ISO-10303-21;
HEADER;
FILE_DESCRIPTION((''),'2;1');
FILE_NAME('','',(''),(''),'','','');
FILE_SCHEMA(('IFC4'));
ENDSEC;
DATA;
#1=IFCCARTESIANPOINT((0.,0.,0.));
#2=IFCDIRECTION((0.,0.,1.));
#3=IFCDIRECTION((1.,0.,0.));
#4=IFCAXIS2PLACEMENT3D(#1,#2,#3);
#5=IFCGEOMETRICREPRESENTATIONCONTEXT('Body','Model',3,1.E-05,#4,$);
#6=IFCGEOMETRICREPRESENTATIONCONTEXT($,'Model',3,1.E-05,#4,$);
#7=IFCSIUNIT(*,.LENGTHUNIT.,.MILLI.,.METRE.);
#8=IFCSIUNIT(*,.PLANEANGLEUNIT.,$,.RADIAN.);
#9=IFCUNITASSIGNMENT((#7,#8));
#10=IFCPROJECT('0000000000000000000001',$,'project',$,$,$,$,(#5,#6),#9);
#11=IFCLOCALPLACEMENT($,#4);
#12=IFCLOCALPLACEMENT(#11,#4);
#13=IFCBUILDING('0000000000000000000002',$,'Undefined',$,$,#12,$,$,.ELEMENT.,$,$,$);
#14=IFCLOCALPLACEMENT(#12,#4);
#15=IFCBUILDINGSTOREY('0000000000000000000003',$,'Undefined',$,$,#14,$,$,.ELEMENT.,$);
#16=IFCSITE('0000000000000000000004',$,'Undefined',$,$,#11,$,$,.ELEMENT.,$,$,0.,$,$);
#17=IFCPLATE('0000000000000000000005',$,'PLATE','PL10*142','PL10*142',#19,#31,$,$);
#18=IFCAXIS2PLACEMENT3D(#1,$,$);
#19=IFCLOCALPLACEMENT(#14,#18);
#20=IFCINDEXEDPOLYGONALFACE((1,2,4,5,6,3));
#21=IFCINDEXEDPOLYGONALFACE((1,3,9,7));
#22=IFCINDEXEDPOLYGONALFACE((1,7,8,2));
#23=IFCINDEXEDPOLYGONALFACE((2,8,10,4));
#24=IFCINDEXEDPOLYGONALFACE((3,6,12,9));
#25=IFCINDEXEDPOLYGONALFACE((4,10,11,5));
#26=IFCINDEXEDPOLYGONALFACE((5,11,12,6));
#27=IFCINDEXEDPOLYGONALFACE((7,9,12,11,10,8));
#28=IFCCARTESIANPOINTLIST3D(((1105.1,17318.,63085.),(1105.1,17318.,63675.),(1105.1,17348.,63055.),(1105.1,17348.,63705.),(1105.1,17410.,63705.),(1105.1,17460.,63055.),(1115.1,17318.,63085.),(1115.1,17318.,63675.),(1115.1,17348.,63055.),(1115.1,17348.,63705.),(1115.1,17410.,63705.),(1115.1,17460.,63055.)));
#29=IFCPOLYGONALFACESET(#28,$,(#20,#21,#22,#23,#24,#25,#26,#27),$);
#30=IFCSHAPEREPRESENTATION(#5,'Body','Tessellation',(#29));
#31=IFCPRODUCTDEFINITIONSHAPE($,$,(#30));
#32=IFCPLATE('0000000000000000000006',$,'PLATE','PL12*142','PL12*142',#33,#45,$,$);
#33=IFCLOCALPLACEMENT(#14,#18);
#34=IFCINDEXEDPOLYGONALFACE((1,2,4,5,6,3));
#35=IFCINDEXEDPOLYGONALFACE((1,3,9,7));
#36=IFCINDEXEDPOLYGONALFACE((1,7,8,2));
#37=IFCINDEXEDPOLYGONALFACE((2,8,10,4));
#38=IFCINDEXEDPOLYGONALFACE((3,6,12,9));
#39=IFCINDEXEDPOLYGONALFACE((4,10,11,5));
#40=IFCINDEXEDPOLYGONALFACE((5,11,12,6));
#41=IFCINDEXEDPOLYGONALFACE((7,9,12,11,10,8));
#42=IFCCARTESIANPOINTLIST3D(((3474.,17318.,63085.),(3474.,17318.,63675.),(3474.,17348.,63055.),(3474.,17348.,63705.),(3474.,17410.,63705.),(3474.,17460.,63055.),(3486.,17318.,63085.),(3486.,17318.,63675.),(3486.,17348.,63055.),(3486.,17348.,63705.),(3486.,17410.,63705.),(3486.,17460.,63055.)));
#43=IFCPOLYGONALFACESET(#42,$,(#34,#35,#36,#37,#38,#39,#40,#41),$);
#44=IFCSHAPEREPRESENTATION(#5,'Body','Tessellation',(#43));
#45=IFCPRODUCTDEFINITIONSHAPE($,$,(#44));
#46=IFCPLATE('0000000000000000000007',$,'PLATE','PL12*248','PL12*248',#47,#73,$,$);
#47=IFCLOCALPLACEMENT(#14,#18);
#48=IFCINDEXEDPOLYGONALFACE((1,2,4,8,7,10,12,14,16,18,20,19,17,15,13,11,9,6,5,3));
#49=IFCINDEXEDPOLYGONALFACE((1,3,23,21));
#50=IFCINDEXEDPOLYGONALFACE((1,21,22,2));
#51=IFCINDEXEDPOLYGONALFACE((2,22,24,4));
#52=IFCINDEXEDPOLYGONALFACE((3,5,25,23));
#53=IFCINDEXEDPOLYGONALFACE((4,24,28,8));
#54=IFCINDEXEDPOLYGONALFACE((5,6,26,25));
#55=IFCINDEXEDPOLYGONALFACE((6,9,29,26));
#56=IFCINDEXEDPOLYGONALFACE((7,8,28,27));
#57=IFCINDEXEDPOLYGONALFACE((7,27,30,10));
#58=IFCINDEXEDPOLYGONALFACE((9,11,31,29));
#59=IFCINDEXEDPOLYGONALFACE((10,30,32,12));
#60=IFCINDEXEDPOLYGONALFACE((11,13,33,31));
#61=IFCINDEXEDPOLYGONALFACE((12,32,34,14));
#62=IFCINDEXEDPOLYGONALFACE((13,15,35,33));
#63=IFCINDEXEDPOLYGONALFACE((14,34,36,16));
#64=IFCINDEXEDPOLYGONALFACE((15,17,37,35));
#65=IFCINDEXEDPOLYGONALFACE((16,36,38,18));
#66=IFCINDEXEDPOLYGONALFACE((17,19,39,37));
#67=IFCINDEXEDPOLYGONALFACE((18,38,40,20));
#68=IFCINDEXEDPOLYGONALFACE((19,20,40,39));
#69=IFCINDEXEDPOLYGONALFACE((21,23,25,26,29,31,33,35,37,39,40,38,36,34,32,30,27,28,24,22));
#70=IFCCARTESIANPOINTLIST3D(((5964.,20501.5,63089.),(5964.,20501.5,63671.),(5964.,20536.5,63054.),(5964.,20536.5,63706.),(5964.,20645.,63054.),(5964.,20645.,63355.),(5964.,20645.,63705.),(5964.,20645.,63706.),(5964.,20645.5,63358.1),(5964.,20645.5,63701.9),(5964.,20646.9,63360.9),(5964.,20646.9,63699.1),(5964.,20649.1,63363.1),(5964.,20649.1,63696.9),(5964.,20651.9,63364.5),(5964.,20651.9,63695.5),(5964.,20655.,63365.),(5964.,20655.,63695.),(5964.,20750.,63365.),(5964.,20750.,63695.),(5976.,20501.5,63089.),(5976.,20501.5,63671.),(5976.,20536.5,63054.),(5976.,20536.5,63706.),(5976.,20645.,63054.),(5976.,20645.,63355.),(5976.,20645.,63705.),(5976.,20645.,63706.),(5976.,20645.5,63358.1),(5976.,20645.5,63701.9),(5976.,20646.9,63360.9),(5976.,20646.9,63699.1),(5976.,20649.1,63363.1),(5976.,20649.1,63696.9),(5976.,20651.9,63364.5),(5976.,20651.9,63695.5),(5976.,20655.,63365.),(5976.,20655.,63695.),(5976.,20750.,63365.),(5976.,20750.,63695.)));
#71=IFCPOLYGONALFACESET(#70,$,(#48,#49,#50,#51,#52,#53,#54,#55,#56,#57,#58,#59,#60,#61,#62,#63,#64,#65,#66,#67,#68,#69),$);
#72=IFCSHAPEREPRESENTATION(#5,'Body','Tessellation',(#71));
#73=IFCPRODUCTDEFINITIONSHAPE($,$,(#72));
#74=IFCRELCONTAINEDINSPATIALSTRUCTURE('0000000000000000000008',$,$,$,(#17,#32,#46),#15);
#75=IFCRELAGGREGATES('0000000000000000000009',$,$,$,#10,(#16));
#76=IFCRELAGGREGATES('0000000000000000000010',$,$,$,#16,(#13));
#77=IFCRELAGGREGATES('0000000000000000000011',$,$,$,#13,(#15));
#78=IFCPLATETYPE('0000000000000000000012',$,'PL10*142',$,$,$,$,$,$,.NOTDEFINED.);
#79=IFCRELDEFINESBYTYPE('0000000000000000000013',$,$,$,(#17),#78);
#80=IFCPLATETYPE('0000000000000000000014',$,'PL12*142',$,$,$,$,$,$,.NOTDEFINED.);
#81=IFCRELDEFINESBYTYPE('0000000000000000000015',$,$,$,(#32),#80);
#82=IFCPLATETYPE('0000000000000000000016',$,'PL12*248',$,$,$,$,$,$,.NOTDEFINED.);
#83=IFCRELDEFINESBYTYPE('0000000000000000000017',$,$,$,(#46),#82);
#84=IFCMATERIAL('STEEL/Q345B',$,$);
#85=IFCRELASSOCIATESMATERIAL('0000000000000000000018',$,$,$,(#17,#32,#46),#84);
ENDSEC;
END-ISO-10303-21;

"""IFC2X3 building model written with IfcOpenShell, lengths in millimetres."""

from ifc_helpers import new_model, si_unit, frame, origin_with_axes, place, context, project, spatial, polyline, outline, extrude, material, type_object, element, save


model = new_model("IFC2X3")

# Units and contexts
model_context_1 = context("Model", 3, precision=1e-05, world=origin_with_axes(), identifier="Body")
model_context_2 = context("Model", 3, precision=1e-05, world=origin_with_axes())
ifc_project = project(units=[si_unit("LENGTHUNIT", "METRE", prefix="MILLI"), si_unit("PLANEANGLEUNIT", "RADIAN")], contexts=[model_context_1, model_context_2])

# Site, building, storey
site_placement = place(None, origin_with_axes())
site = spatial("IfcSite", under=ifc_project, at=site_placement, Name="Undefined", CompositionType="ELEMENT", RefElevation=0.0)
building_placement = place(site_placement, origin_with_axes())
building = spatial("IfcBuilding", under=site, at=building_placement, Name="Undefined", CompositionType="ELEMENT")
storey_placement = place(building_placement, origin_with_axes())
storey = spatial("IfcBuildingStorey", under=building, at=storey_placement, Name="Undefined", CompositionType="ELEMENT")

# Shared definitions
ifc_material_1 = material(Name="STEEL/Q345B")

# Plates
plate_type_1 = type_object("IfcPlateType", Name="PL10*142", PredefinedType="NOTDEFINED")
plate_1_placement = place(storey_placement, frame((1110.1, 17318.0, 63055.0), z_axis=(1.0, 0.0, 0.0), x_axis=(0.0, 1.0, 0.0)))
element("IfcPlate", 1, at=plate_1_placement, inside=storey, type_object=plate_type_1, material=ifc_material_1, Name="PLATE", Description="PL10*142", ObjectType="PL10*142", context=model_context_1, shape_type="SweptSolid", body=[
    extrude(outline(polyline([(0.0, 30.0), (30.0, 0.0), (142.0, 0.0), (92.0, 650.0), (30.0, 650.0), (0.0, 620.0), (0.0, 30.0)])), frame((0.0, 0.0, -5.0), z_axis=(0.0, 0.0, 1.0), x_axis=(1.0, 0.0, 0.0)), (0.0, 0.0, 1.0), 10.0),
])
plate_type_2 = type_object("IfcPlateType", Name="PL12*142", PredefinedType="NOTDEFINED")
plate_2_placement = place(storey_placement, frame((3480.0, 17318.0, 63055.0), z_axis=(1.0, 0.0, 0.0), x_axis=(0.0, 1.0, 0.0)))
element("IfcPlate", 2, at=plate_2_placement, inside=storey, type_object=plate_type_2, material=ifc_material_1, Name="PLATE", Description="PL12*142", ObjectType="PL12*142", context=model_context_1, shape_type="SweptSolid", body=[
    extrude(outline(polyline([(0.0, 30.0), (30.0, 0.0), (142.0, 0.0), (92.0, 650.0), (30.0, 650.0), (0.0, 620.0), (0.0, 30.0)])), frame((0.0, 0.0, -6.0), z_axis=(0.0, 0.0, 1.0), x_axis=(1.0, 0.0, 0.0)), (0.0, 0.0, 1.0), 12.0),
])
plate_type_3 = type_object("IfcPlateType", Name="PL12*248", PredefinedType="NOTDEFINED")
for number, where, z_axis, x_axis, name in (
    (3, (5970.0, 20501.5, 63089.0), (1.0, 0.0, 0.0), (0.0, 0.707107, -0.707107), "PLATE"),
):
    element("IfcPlate", number, at=place(storey_placement, frame(where, z_axis=z_axis, x_axis=x_axis)), inside=storey, type_object=plate_type_3, material=ifc_material_1, Name=name, Description="PL12*248", ObjectType="PL12*248", context=model_context_1, shape_type="SweptSolid", body=[
        extrude(outline(polyline([(0.0, 0.0), (49.5, 0.0), (126.2, 76.7), (-86.6, 289.6), (-88.5, 292.1), (-89.4, 295.1), (-89.4, 298.2), (-88.5, 301.2), (-86.6, 303.7), (-19.4, 370.9), (-252.8, 604.2), (-320.0, 537.0), (-322.5, 535.2), (-325.5, 534.2), (-328.6, 534.2), (-331.6, 535.2), (-334.1, 537.0), (-334.8, 537.8), (-411.5, 461.0), (-411.5, 411.5), (0.0, 0.0)])), frame((0.0, 0.0, -6.0), z_axis=(0.0, 0.0, 1.0), x_axis=(1.0, 0.0, 0.0)), (0.0, 0.0, 1.0), 12.0),
    ])

save(model, "model.ifc")
